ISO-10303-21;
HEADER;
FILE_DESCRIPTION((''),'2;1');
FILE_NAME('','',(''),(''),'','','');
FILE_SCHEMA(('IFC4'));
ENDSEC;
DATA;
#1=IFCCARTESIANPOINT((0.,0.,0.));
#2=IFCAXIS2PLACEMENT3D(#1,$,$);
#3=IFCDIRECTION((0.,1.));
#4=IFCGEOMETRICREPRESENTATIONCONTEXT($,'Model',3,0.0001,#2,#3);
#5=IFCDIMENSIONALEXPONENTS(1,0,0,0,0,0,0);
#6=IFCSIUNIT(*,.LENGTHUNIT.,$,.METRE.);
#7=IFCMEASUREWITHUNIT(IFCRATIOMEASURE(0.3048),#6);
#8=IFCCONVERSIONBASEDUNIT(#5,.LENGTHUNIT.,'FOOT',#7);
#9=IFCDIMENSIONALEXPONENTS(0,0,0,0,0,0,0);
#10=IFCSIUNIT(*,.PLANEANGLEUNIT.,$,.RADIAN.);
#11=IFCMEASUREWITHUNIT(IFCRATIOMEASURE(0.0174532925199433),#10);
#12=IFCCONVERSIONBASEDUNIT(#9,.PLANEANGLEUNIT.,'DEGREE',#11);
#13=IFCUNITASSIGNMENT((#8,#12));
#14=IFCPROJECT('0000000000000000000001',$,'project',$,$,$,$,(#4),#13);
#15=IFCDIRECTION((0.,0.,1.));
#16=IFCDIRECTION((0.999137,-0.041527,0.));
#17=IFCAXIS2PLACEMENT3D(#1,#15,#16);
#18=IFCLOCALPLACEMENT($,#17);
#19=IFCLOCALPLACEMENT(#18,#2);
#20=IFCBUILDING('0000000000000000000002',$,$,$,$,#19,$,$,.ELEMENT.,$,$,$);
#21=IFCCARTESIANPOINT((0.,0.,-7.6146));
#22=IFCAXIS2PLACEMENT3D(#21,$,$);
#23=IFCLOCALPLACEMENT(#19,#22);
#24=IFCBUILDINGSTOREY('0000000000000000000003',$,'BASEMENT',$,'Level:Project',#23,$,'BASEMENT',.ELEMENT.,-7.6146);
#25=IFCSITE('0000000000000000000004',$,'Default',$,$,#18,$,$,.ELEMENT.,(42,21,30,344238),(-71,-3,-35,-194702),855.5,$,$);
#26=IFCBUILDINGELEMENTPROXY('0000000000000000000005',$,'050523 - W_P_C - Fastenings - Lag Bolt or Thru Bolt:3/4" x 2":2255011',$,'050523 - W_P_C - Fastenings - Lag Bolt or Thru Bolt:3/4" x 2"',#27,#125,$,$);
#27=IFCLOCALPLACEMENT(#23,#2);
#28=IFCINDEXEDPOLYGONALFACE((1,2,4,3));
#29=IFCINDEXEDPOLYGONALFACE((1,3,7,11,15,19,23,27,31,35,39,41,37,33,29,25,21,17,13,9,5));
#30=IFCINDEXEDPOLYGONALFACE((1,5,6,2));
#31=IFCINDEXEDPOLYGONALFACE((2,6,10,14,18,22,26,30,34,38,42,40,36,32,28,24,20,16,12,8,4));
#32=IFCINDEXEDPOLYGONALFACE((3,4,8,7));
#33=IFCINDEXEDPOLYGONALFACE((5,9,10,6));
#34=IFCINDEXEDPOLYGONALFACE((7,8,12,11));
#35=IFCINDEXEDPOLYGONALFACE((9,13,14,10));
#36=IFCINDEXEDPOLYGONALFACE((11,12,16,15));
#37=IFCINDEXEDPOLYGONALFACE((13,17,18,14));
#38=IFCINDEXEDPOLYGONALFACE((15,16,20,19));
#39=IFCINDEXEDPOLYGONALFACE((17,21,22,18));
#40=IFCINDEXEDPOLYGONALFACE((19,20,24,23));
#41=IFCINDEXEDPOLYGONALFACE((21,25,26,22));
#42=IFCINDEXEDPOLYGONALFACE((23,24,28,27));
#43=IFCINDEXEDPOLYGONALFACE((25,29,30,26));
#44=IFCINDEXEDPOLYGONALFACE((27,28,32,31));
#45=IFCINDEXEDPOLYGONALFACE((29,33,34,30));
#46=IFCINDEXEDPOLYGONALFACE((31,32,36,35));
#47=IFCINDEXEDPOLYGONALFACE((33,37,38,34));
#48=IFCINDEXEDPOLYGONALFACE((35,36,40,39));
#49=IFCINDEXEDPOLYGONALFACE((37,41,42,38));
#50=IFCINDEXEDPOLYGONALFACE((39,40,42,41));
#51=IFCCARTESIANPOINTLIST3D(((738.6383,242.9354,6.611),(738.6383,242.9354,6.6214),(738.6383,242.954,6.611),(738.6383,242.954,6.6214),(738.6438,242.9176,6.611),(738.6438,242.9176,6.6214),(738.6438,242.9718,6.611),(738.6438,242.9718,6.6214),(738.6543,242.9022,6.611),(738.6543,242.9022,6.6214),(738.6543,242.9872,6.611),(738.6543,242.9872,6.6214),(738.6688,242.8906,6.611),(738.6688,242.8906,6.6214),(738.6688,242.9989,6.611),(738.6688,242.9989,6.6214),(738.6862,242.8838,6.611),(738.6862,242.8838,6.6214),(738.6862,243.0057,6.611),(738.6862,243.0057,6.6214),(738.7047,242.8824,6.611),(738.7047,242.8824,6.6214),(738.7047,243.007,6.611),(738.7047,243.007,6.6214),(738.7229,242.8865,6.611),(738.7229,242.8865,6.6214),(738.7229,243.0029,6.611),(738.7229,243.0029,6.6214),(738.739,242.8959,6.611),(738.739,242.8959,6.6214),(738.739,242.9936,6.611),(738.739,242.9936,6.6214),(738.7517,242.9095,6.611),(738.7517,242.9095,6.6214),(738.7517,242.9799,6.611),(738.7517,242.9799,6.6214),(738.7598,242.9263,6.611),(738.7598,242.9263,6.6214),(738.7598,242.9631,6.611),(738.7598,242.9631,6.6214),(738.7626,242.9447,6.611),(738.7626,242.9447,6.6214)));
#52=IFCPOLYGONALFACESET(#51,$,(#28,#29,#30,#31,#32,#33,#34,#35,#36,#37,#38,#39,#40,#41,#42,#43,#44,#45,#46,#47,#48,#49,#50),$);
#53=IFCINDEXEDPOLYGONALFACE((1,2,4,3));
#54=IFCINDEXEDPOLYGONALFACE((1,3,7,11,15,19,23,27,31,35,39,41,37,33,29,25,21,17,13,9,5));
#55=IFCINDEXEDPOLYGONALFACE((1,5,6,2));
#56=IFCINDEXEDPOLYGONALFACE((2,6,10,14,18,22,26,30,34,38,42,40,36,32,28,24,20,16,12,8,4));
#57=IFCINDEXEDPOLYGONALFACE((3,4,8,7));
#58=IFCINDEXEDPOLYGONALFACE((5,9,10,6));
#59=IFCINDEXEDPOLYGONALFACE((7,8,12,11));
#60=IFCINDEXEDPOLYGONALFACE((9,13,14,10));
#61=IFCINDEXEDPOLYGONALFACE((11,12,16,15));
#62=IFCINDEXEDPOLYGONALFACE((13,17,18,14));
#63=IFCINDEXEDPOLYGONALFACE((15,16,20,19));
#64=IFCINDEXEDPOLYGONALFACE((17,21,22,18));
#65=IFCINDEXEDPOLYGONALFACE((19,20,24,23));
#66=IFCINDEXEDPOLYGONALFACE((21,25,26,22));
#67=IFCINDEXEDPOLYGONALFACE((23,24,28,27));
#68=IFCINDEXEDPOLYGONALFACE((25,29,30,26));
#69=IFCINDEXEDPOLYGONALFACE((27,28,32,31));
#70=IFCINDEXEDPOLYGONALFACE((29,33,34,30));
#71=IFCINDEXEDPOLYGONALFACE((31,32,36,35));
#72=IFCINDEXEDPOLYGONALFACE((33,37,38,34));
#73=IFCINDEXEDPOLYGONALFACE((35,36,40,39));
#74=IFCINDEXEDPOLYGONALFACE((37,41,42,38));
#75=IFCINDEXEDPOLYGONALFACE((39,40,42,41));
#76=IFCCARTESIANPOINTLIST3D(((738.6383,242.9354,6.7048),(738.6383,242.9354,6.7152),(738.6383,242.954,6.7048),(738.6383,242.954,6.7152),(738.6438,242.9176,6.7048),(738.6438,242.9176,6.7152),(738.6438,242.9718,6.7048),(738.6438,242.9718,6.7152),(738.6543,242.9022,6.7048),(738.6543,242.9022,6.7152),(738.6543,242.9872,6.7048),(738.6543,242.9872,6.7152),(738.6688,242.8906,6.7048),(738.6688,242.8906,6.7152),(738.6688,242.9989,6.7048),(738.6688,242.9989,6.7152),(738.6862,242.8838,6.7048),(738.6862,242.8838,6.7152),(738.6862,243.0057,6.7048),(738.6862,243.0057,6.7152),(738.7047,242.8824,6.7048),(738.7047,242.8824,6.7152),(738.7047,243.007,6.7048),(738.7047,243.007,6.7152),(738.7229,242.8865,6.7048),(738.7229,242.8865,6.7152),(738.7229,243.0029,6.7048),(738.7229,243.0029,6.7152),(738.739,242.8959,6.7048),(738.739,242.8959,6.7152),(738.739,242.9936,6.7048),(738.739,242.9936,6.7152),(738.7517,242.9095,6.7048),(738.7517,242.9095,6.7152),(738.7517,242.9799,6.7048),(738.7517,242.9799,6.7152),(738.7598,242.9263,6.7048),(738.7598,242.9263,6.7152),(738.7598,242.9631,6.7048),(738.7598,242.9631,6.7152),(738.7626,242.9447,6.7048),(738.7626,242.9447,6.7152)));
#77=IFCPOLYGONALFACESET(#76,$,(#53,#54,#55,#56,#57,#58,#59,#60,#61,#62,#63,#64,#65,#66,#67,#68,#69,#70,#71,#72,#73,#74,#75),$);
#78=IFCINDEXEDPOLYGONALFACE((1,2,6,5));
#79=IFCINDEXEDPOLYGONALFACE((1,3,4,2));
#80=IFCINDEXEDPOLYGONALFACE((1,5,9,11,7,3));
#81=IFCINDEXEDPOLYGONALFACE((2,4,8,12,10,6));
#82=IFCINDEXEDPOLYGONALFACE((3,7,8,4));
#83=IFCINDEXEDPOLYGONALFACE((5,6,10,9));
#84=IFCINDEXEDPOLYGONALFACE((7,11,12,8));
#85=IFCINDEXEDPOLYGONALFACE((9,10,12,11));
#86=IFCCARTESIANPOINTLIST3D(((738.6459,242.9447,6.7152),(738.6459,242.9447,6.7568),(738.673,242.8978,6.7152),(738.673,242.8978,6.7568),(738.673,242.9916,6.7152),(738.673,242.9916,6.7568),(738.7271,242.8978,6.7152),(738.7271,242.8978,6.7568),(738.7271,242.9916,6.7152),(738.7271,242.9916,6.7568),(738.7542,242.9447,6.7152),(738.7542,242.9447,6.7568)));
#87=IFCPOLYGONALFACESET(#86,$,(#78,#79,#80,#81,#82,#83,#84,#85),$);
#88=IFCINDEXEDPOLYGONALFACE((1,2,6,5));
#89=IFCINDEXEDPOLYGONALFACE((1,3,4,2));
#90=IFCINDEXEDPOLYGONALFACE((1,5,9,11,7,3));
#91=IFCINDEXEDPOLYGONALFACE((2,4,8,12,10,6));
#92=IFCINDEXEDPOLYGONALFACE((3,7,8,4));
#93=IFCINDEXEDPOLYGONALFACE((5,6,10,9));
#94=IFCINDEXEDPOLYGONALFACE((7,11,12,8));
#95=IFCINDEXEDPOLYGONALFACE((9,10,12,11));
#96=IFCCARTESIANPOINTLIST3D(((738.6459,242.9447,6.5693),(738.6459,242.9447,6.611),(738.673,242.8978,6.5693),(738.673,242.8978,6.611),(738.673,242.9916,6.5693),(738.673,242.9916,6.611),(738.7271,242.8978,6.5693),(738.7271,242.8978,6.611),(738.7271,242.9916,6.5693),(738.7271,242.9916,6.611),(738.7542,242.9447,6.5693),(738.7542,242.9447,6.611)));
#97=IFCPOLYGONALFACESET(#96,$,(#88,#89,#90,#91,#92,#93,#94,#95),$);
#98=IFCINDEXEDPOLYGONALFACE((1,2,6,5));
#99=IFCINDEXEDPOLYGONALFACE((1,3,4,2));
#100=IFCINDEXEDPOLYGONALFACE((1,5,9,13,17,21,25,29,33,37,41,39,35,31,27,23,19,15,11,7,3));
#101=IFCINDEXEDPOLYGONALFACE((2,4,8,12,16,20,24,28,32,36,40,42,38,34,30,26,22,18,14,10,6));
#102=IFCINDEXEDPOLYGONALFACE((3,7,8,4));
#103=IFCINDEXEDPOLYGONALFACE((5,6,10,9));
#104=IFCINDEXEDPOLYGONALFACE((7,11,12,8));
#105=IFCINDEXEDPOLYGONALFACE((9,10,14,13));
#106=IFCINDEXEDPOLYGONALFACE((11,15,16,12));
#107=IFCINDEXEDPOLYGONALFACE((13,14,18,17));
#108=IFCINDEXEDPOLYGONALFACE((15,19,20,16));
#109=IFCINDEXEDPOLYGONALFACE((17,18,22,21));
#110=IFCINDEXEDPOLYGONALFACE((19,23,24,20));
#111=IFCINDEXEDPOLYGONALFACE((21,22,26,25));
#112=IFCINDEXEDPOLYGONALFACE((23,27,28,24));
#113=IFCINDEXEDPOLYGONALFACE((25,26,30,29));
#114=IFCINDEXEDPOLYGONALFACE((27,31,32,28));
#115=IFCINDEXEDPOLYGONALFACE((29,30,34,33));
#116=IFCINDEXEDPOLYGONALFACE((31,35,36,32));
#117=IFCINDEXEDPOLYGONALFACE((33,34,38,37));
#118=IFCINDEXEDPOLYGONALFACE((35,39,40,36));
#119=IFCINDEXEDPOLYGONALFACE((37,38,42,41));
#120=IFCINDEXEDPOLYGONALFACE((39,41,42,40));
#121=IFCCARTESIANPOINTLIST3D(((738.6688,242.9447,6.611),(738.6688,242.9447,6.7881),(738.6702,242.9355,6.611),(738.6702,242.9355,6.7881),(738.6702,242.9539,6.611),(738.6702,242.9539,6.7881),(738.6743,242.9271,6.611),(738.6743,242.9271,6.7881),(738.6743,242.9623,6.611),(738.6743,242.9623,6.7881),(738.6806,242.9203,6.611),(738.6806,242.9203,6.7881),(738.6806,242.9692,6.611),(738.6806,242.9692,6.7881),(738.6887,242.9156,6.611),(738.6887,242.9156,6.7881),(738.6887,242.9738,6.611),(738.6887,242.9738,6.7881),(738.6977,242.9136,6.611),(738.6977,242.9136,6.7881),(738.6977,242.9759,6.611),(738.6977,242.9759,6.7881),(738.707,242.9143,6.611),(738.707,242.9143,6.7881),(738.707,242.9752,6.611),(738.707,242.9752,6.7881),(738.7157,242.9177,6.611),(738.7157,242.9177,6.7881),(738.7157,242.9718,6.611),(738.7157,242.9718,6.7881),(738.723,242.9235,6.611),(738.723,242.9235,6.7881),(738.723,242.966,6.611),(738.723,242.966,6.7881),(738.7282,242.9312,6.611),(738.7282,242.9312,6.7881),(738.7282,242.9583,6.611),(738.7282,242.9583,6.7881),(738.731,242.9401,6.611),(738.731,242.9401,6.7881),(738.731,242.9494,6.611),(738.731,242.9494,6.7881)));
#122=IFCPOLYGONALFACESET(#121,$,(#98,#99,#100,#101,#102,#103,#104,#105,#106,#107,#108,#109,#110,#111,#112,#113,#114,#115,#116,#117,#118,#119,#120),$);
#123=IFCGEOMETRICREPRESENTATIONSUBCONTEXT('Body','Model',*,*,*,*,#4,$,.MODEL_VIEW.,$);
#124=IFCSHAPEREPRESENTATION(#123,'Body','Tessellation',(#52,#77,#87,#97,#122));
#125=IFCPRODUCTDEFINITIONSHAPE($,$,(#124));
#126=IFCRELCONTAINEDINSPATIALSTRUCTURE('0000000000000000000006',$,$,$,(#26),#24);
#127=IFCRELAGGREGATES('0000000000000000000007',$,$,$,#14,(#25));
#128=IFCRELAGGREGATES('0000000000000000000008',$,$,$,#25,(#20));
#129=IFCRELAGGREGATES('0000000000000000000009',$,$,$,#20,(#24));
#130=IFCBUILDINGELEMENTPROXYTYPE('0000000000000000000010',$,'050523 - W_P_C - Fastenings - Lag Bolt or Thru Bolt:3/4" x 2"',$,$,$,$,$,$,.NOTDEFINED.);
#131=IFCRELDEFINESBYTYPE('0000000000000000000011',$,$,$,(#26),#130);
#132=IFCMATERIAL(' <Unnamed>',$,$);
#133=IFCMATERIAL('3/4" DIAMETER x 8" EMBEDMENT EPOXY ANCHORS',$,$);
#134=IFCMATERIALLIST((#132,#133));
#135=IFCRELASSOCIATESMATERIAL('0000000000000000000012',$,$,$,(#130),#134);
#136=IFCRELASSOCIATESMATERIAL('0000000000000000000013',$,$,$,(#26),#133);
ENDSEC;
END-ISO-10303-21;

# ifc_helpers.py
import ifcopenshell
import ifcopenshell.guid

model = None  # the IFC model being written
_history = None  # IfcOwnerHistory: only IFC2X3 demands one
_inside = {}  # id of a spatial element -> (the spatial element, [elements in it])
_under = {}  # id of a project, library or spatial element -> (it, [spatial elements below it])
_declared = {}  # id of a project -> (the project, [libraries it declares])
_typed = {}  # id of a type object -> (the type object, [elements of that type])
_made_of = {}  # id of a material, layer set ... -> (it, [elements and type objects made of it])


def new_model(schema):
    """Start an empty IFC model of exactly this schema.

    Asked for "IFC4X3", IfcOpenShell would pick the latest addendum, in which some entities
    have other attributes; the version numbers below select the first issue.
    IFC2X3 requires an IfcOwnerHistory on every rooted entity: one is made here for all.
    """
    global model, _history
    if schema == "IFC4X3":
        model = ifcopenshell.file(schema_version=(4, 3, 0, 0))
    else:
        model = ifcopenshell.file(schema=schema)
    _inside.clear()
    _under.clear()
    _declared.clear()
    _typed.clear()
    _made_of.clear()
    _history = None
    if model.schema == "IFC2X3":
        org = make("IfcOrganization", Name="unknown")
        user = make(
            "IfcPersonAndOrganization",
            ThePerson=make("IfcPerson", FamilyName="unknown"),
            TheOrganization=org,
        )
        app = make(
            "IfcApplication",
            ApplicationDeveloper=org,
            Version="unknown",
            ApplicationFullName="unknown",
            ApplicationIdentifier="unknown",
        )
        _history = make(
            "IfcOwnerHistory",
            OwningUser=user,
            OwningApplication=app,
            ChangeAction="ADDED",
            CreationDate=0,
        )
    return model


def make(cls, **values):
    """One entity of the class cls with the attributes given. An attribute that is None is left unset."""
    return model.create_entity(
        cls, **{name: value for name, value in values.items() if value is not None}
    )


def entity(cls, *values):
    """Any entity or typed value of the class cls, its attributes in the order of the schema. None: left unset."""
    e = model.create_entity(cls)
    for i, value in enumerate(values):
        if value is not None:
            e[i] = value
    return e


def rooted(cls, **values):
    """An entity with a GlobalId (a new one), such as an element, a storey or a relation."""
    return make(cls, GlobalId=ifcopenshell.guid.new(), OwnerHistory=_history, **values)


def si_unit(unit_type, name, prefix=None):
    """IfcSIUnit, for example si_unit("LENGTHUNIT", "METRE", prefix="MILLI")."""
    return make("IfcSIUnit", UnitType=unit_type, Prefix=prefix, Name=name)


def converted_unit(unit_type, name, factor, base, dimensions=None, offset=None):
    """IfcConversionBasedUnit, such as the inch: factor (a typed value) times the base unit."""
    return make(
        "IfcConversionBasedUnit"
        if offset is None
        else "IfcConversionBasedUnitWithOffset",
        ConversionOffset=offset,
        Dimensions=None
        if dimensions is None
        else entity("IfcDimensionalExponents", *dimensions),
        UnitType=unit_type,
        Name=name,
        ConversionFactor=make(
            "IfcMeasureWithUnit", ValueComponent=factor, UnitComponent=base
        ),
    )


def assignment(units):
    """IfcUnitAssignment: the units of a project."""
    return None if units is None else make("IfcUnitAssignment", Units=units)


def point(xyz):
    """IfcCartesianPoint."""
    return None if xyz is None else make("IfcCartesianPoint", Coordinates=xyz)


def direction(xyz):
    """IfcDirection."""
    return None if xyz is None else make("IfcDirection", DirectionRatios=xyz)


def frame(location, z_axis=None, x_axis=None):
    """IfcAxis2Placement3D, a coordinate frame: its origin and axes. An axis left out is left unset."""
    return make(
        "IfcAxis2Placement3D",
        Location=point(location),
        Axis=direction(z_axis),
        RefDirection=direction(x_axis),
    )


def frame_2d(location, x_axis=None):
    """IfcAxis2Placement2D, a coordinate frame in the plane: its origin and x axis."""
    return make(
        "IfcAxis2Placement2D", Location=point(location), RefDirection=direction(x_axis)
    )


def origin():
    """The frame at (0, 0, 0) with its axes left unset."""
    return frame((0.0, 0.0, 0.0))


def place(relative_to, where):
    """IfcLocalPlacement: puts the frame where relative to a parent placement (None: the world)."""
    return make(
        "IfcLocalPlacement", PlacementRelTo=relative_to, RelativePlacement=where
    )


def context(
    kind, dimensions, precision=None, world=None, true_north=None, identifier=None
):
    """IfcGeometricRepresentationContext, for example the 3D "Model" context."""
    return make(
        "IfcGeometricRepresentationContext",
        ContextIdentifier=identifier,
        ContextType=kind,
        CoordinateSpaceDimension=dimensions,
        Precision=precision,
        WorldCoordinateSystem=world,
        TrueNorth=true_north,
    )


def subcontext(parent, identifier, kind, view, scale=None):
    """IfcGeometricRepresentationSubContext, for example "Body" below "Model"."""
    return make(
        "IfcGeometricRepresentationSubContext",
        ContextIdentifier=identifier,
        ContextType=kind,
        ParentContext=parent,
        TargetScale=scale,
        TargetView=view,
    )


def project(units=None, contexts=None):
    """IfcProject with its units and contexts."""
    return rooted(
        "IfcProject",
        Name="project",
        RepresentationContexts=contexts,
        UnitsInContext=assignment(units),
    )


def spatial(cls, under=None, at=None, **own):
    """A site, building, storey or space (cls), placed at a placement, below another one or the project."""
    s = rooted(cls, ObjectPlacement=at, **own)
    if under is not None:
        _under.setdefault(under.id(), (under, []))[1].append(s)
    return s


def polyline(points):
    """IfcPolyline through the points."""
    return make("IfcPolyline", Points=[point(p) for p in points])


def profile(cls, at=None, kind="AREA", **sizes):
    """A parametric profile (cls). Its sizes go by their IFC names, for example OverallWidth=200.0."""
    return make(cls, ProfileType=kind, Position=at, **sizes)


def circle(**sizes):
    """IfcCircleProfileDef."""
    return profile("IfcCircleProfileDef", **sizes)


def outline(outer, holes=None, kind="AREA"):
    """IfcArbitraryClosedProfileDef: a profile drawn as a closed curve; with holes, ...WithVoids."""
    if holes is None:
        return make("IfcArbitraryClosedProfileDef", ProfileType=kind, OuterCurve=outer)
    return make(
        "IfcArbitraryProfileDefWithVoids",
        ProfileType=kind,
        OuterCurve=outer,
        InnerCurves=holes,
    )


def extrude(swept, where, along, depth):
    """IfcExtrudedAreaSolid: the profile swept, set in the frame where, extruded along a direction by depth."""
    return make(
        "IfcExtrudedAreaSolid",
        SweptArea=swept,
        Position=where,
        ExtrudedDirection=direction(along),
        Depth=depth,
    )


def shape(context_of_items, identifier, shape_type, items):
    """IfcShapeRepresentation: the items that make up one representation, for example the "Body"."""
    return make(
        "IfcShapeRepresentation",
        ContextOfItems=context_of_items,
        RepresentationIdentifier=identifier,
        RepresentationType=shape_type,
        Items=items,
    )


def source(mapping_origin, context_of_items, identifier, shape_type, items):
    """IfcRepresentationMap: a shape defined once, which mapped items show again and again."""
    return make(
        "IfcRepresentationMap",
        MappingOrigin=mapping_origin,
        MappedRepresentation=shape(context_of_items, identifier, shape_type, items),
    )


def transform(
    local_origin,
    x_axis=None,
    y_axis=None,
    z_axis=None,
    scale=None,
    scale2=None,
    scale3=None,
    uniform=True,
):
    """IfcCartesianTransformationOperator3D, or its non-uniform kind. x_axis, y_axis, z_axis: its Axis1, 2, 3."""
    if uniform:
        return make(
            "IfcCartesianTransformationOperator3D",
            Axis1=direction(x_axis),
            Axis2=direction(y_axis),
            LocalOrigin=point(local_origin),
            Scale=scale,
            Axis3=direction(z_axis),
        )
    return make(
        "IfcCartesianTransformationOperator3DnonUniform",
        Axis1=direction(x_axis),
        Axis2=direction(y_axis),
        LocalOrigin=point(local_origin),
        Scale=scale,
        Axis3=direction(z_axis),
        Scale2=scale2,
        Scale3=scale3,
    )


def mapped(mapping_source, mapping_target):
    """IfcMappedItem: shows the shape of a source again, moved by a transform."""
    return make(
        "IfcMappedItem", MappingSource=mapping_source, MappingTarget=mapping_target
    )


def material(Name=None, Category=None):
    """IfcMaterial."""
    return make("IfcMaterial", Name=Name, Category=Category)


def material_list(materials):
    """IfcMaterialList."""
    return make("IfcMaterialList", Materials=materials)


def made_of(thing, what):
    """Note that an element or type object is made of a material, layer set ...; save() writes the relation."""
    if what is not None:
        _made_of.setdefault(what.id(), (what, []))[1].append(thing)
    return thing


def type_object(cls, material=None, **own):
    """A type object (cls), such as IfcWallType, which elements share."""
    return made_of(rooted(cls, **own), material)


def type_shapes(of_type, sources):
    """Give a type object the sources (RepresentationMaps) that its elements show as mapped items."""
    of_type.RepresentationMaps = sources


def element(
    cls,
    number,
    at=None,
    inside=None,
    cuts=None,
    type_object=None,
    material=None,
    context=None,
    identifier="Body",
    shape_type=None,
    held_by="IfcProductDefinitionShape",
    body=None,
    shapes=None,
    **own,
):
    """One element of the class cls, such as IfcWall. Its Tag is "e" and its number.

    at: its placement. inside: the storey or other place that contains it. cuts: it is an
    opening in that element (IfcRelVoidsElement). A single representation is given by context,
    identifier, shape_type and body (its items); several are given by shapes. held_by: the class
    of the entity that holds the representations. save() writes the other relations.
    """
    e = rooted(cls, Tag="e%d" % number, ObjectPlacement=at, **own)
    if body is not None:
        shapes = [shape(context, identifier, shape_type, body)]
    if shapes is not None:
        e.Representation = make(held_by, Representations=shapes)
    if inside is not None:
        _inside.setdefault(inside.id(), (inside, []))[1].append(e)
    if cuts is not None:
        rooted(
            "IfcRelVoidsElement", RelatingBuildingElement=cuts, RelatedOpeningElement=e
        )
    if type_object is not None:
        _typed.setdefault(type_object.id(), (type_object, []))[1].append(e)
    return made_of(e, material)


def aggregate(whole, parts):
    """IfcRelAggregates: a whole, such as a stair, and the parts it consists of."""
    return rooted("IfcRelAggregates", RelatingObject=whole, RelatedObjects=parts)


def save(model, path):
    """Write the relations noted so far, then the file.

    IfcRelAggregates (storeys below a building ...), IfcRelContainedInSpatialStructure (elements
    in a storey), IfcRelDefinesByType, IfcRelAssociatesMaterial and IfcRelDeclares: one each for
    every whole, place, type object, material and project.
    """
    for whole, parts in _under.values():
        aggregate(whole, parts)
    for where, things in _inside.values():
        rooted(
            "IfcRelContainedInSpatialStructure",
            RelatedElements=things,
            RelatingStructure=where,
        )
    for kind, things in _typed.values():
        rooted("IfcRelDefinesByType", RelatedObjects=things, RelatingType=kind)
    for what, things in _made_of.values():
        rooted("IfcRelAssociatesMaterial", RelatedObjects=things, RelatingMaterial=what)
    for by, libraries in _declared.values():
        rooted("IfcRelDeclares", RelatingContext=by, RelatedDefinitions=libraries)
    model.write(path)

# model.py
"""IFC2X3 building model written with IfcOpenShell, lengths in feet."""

from ifc_helpers import new_model, entity, si_unit, converted_unit, direction, frame, frame_2d, origin, place, context, subcontext, project, spatial, polyline, circle, outline, extrude, source, transform, mapped, material, material_list, type_object, type_shapes, element, save


model = new_model("IFC2X3")

# Units and contexts
model_context = context("Model", 3, precision=0.0001, world=origin(), true_north=direction((0.0, 1.0)))
body_context = subcontext(model_context, "Body", "Model", "MODEL_VIEW")
ifc_project = project(units=[converted_unit("LENGTHUNIT", "FOOT", entity("IfcRatioMeasure", 0.3048), si_unit("LENGTHUNIT", "METRE"), dimensions=[1, 0, 0, 0, 0, 0, 0]), converted_unit("PLANEANGLEUNIT", "DEGREE", entity("IfcRatioMeasure", 0.0174532925199433), si_unit("PLANEANGLEUNIT", "RADIAN"), dimensions=[0, 0, 0, 0, 0, 0, 0])], contexts=[model_context])

# Site, building, storey
site_placement = place(None, frame((0.0, 0.0, 0.0), z_axis=(0.0, 0.0, 1.0), x_axis=(0.999137, -0.041527, 0.0)))
site = spatial("IfcSite", under=ifc_project, at=site_placement, Name="Default", CompositionType="ELEMENT", RefLatitude=(42, 21, 30, 344238), RefLongitude=(-71, -3, -35, -194702), RefElevation=855.5)
building_placement = place(site_placement, origin())
building = spatial("IfcBuilding", under=site, at=building_placement, CompositionType="ELEMENT")
storey_placement = place(building_placement, frame((0.0, 0.0, -7.6146)))
storey = spatial("IfcBuildingStorey", under=building, at=storey_placement, Name="BASEMENT", ObjectType="Level:Project", LongName="BASEMENT", CompositionType="ELEMENT", Elevation=-7.6146)

# Building element proxy
ifc_material_1 = material(Name=" <Unnamed>")
ifc_material_2 = material(Name="3/4\" DIAMETER x 8\" EMBEDMENT EPOXY ANCHORS")
ifc_material_list_1 = material_list([ifc_material_1, ifc_material_2])
building_element_proxy_type_1 = type_object("IfcBuildingElementProxyType", Name="050523 - W_P_C - Fastenings - Lag Bolt or Thru Bolt:3/4\" x 2\"", PredefinedType="NOTDEFINED", material=ifc_material_list_1)
shared_shape_1 = source(origin(), body_context, "Body", "SweptSolid", [
    extrude(circle(Radius=0.0625, at=frame_2d((0.0, 0.0), x_axis=(1.0, 0.0))), frame((0.0, 0.0, 0.0), z_axis=(0.0, 0.0, 1.0), x_axis=(0.0, -1.0, 0.0)), (0.0, 0.0, 1.0), 0.0104),
    extrude(circle(Radius=0.0625, at=frame_2d((0.0, 0.0), x_axis=(1.0, 0.0))), frame((0.0, 0.0, -0.0938), z_axis=(0.0, 0.0, 1.0), x_axis=(0.0, -1.0, 0.0)), (0.0, 0.0, 1.0), 0.0104),
    extrude(outline(polyline([(-0.0271, -0.0469), (0.0271, -0.0469), (0.0541, 0.0), (0.0271, 0.0469), (-0.0271, 0.0469), (-0.0541, 0.0), (-0.0271, -0.0469)])), frame((0.0, 0.0, -0.1354), z_axis=(0.0, 0.0, 1.0), x_axis=(0.866025, -0.5, 0.0)), (0.0, 0.0, 1.0), 0.0417),
    extrude(outline(polyline([(-0.0271, -0.0469), (0.0271, -0.0469), (0.0541, 0.0), (0.0271, 0.0469), (-0.0271, 0.0469), (-0.0541, 0.0), (-0.0271, -0.0469)])), frame((0.0, 0.0, 0.0104), z_axis=(0.0, 0.0, 1.0), x_axis=(0.0, -1.0, 0.0)), (0.0, 0.0, 1.0), 0.0417),
    extrude(circle(Radius=0.0312, at=frame_2d((0.0, 0.0), x_axis=(1.0, 0.0))), frame((0.0, 0.0, -0.1667), z_axis=(0.0, 0.0, 1.0), x_axis=(0.0, 1.0, 0.0)), (0.0, 0.0, 1.0), 0.1771),
])
type_shapes(building_element_proxy_type_1, [shared_shape_1])
for number, where, z_axis, x_axis, name in (
    (1, (738.7001, 242.9447, 6.6214), (0.0, 0.0, -1.0), (0.0, -1.0, 0.0), "050523 - W_P_C - Fastenings - Lag Bolt or Thru Bolt:3/4\" x 2\":2255011"),
):
    element("IfcBuildingElementProxy", number, at=place(storey_placement, frame(where, z_axis=z_axis, x_axis=x_axis)), inside=storey, type_object=building_element_proxy_type_1, material=ifc_material_2, Name=name, ObjectType="050523 - W_P_C - Fastenings - Lag Bolt or Thru Bolt:3/4\" x 2\"", context=body_context, shape_type="MappedRepresentation", body=[
        mapped(shared_shape_1, transform((0.0, 0.0, 0.0), scale=1.0)),
    ])

save(model, "model.ifc")
